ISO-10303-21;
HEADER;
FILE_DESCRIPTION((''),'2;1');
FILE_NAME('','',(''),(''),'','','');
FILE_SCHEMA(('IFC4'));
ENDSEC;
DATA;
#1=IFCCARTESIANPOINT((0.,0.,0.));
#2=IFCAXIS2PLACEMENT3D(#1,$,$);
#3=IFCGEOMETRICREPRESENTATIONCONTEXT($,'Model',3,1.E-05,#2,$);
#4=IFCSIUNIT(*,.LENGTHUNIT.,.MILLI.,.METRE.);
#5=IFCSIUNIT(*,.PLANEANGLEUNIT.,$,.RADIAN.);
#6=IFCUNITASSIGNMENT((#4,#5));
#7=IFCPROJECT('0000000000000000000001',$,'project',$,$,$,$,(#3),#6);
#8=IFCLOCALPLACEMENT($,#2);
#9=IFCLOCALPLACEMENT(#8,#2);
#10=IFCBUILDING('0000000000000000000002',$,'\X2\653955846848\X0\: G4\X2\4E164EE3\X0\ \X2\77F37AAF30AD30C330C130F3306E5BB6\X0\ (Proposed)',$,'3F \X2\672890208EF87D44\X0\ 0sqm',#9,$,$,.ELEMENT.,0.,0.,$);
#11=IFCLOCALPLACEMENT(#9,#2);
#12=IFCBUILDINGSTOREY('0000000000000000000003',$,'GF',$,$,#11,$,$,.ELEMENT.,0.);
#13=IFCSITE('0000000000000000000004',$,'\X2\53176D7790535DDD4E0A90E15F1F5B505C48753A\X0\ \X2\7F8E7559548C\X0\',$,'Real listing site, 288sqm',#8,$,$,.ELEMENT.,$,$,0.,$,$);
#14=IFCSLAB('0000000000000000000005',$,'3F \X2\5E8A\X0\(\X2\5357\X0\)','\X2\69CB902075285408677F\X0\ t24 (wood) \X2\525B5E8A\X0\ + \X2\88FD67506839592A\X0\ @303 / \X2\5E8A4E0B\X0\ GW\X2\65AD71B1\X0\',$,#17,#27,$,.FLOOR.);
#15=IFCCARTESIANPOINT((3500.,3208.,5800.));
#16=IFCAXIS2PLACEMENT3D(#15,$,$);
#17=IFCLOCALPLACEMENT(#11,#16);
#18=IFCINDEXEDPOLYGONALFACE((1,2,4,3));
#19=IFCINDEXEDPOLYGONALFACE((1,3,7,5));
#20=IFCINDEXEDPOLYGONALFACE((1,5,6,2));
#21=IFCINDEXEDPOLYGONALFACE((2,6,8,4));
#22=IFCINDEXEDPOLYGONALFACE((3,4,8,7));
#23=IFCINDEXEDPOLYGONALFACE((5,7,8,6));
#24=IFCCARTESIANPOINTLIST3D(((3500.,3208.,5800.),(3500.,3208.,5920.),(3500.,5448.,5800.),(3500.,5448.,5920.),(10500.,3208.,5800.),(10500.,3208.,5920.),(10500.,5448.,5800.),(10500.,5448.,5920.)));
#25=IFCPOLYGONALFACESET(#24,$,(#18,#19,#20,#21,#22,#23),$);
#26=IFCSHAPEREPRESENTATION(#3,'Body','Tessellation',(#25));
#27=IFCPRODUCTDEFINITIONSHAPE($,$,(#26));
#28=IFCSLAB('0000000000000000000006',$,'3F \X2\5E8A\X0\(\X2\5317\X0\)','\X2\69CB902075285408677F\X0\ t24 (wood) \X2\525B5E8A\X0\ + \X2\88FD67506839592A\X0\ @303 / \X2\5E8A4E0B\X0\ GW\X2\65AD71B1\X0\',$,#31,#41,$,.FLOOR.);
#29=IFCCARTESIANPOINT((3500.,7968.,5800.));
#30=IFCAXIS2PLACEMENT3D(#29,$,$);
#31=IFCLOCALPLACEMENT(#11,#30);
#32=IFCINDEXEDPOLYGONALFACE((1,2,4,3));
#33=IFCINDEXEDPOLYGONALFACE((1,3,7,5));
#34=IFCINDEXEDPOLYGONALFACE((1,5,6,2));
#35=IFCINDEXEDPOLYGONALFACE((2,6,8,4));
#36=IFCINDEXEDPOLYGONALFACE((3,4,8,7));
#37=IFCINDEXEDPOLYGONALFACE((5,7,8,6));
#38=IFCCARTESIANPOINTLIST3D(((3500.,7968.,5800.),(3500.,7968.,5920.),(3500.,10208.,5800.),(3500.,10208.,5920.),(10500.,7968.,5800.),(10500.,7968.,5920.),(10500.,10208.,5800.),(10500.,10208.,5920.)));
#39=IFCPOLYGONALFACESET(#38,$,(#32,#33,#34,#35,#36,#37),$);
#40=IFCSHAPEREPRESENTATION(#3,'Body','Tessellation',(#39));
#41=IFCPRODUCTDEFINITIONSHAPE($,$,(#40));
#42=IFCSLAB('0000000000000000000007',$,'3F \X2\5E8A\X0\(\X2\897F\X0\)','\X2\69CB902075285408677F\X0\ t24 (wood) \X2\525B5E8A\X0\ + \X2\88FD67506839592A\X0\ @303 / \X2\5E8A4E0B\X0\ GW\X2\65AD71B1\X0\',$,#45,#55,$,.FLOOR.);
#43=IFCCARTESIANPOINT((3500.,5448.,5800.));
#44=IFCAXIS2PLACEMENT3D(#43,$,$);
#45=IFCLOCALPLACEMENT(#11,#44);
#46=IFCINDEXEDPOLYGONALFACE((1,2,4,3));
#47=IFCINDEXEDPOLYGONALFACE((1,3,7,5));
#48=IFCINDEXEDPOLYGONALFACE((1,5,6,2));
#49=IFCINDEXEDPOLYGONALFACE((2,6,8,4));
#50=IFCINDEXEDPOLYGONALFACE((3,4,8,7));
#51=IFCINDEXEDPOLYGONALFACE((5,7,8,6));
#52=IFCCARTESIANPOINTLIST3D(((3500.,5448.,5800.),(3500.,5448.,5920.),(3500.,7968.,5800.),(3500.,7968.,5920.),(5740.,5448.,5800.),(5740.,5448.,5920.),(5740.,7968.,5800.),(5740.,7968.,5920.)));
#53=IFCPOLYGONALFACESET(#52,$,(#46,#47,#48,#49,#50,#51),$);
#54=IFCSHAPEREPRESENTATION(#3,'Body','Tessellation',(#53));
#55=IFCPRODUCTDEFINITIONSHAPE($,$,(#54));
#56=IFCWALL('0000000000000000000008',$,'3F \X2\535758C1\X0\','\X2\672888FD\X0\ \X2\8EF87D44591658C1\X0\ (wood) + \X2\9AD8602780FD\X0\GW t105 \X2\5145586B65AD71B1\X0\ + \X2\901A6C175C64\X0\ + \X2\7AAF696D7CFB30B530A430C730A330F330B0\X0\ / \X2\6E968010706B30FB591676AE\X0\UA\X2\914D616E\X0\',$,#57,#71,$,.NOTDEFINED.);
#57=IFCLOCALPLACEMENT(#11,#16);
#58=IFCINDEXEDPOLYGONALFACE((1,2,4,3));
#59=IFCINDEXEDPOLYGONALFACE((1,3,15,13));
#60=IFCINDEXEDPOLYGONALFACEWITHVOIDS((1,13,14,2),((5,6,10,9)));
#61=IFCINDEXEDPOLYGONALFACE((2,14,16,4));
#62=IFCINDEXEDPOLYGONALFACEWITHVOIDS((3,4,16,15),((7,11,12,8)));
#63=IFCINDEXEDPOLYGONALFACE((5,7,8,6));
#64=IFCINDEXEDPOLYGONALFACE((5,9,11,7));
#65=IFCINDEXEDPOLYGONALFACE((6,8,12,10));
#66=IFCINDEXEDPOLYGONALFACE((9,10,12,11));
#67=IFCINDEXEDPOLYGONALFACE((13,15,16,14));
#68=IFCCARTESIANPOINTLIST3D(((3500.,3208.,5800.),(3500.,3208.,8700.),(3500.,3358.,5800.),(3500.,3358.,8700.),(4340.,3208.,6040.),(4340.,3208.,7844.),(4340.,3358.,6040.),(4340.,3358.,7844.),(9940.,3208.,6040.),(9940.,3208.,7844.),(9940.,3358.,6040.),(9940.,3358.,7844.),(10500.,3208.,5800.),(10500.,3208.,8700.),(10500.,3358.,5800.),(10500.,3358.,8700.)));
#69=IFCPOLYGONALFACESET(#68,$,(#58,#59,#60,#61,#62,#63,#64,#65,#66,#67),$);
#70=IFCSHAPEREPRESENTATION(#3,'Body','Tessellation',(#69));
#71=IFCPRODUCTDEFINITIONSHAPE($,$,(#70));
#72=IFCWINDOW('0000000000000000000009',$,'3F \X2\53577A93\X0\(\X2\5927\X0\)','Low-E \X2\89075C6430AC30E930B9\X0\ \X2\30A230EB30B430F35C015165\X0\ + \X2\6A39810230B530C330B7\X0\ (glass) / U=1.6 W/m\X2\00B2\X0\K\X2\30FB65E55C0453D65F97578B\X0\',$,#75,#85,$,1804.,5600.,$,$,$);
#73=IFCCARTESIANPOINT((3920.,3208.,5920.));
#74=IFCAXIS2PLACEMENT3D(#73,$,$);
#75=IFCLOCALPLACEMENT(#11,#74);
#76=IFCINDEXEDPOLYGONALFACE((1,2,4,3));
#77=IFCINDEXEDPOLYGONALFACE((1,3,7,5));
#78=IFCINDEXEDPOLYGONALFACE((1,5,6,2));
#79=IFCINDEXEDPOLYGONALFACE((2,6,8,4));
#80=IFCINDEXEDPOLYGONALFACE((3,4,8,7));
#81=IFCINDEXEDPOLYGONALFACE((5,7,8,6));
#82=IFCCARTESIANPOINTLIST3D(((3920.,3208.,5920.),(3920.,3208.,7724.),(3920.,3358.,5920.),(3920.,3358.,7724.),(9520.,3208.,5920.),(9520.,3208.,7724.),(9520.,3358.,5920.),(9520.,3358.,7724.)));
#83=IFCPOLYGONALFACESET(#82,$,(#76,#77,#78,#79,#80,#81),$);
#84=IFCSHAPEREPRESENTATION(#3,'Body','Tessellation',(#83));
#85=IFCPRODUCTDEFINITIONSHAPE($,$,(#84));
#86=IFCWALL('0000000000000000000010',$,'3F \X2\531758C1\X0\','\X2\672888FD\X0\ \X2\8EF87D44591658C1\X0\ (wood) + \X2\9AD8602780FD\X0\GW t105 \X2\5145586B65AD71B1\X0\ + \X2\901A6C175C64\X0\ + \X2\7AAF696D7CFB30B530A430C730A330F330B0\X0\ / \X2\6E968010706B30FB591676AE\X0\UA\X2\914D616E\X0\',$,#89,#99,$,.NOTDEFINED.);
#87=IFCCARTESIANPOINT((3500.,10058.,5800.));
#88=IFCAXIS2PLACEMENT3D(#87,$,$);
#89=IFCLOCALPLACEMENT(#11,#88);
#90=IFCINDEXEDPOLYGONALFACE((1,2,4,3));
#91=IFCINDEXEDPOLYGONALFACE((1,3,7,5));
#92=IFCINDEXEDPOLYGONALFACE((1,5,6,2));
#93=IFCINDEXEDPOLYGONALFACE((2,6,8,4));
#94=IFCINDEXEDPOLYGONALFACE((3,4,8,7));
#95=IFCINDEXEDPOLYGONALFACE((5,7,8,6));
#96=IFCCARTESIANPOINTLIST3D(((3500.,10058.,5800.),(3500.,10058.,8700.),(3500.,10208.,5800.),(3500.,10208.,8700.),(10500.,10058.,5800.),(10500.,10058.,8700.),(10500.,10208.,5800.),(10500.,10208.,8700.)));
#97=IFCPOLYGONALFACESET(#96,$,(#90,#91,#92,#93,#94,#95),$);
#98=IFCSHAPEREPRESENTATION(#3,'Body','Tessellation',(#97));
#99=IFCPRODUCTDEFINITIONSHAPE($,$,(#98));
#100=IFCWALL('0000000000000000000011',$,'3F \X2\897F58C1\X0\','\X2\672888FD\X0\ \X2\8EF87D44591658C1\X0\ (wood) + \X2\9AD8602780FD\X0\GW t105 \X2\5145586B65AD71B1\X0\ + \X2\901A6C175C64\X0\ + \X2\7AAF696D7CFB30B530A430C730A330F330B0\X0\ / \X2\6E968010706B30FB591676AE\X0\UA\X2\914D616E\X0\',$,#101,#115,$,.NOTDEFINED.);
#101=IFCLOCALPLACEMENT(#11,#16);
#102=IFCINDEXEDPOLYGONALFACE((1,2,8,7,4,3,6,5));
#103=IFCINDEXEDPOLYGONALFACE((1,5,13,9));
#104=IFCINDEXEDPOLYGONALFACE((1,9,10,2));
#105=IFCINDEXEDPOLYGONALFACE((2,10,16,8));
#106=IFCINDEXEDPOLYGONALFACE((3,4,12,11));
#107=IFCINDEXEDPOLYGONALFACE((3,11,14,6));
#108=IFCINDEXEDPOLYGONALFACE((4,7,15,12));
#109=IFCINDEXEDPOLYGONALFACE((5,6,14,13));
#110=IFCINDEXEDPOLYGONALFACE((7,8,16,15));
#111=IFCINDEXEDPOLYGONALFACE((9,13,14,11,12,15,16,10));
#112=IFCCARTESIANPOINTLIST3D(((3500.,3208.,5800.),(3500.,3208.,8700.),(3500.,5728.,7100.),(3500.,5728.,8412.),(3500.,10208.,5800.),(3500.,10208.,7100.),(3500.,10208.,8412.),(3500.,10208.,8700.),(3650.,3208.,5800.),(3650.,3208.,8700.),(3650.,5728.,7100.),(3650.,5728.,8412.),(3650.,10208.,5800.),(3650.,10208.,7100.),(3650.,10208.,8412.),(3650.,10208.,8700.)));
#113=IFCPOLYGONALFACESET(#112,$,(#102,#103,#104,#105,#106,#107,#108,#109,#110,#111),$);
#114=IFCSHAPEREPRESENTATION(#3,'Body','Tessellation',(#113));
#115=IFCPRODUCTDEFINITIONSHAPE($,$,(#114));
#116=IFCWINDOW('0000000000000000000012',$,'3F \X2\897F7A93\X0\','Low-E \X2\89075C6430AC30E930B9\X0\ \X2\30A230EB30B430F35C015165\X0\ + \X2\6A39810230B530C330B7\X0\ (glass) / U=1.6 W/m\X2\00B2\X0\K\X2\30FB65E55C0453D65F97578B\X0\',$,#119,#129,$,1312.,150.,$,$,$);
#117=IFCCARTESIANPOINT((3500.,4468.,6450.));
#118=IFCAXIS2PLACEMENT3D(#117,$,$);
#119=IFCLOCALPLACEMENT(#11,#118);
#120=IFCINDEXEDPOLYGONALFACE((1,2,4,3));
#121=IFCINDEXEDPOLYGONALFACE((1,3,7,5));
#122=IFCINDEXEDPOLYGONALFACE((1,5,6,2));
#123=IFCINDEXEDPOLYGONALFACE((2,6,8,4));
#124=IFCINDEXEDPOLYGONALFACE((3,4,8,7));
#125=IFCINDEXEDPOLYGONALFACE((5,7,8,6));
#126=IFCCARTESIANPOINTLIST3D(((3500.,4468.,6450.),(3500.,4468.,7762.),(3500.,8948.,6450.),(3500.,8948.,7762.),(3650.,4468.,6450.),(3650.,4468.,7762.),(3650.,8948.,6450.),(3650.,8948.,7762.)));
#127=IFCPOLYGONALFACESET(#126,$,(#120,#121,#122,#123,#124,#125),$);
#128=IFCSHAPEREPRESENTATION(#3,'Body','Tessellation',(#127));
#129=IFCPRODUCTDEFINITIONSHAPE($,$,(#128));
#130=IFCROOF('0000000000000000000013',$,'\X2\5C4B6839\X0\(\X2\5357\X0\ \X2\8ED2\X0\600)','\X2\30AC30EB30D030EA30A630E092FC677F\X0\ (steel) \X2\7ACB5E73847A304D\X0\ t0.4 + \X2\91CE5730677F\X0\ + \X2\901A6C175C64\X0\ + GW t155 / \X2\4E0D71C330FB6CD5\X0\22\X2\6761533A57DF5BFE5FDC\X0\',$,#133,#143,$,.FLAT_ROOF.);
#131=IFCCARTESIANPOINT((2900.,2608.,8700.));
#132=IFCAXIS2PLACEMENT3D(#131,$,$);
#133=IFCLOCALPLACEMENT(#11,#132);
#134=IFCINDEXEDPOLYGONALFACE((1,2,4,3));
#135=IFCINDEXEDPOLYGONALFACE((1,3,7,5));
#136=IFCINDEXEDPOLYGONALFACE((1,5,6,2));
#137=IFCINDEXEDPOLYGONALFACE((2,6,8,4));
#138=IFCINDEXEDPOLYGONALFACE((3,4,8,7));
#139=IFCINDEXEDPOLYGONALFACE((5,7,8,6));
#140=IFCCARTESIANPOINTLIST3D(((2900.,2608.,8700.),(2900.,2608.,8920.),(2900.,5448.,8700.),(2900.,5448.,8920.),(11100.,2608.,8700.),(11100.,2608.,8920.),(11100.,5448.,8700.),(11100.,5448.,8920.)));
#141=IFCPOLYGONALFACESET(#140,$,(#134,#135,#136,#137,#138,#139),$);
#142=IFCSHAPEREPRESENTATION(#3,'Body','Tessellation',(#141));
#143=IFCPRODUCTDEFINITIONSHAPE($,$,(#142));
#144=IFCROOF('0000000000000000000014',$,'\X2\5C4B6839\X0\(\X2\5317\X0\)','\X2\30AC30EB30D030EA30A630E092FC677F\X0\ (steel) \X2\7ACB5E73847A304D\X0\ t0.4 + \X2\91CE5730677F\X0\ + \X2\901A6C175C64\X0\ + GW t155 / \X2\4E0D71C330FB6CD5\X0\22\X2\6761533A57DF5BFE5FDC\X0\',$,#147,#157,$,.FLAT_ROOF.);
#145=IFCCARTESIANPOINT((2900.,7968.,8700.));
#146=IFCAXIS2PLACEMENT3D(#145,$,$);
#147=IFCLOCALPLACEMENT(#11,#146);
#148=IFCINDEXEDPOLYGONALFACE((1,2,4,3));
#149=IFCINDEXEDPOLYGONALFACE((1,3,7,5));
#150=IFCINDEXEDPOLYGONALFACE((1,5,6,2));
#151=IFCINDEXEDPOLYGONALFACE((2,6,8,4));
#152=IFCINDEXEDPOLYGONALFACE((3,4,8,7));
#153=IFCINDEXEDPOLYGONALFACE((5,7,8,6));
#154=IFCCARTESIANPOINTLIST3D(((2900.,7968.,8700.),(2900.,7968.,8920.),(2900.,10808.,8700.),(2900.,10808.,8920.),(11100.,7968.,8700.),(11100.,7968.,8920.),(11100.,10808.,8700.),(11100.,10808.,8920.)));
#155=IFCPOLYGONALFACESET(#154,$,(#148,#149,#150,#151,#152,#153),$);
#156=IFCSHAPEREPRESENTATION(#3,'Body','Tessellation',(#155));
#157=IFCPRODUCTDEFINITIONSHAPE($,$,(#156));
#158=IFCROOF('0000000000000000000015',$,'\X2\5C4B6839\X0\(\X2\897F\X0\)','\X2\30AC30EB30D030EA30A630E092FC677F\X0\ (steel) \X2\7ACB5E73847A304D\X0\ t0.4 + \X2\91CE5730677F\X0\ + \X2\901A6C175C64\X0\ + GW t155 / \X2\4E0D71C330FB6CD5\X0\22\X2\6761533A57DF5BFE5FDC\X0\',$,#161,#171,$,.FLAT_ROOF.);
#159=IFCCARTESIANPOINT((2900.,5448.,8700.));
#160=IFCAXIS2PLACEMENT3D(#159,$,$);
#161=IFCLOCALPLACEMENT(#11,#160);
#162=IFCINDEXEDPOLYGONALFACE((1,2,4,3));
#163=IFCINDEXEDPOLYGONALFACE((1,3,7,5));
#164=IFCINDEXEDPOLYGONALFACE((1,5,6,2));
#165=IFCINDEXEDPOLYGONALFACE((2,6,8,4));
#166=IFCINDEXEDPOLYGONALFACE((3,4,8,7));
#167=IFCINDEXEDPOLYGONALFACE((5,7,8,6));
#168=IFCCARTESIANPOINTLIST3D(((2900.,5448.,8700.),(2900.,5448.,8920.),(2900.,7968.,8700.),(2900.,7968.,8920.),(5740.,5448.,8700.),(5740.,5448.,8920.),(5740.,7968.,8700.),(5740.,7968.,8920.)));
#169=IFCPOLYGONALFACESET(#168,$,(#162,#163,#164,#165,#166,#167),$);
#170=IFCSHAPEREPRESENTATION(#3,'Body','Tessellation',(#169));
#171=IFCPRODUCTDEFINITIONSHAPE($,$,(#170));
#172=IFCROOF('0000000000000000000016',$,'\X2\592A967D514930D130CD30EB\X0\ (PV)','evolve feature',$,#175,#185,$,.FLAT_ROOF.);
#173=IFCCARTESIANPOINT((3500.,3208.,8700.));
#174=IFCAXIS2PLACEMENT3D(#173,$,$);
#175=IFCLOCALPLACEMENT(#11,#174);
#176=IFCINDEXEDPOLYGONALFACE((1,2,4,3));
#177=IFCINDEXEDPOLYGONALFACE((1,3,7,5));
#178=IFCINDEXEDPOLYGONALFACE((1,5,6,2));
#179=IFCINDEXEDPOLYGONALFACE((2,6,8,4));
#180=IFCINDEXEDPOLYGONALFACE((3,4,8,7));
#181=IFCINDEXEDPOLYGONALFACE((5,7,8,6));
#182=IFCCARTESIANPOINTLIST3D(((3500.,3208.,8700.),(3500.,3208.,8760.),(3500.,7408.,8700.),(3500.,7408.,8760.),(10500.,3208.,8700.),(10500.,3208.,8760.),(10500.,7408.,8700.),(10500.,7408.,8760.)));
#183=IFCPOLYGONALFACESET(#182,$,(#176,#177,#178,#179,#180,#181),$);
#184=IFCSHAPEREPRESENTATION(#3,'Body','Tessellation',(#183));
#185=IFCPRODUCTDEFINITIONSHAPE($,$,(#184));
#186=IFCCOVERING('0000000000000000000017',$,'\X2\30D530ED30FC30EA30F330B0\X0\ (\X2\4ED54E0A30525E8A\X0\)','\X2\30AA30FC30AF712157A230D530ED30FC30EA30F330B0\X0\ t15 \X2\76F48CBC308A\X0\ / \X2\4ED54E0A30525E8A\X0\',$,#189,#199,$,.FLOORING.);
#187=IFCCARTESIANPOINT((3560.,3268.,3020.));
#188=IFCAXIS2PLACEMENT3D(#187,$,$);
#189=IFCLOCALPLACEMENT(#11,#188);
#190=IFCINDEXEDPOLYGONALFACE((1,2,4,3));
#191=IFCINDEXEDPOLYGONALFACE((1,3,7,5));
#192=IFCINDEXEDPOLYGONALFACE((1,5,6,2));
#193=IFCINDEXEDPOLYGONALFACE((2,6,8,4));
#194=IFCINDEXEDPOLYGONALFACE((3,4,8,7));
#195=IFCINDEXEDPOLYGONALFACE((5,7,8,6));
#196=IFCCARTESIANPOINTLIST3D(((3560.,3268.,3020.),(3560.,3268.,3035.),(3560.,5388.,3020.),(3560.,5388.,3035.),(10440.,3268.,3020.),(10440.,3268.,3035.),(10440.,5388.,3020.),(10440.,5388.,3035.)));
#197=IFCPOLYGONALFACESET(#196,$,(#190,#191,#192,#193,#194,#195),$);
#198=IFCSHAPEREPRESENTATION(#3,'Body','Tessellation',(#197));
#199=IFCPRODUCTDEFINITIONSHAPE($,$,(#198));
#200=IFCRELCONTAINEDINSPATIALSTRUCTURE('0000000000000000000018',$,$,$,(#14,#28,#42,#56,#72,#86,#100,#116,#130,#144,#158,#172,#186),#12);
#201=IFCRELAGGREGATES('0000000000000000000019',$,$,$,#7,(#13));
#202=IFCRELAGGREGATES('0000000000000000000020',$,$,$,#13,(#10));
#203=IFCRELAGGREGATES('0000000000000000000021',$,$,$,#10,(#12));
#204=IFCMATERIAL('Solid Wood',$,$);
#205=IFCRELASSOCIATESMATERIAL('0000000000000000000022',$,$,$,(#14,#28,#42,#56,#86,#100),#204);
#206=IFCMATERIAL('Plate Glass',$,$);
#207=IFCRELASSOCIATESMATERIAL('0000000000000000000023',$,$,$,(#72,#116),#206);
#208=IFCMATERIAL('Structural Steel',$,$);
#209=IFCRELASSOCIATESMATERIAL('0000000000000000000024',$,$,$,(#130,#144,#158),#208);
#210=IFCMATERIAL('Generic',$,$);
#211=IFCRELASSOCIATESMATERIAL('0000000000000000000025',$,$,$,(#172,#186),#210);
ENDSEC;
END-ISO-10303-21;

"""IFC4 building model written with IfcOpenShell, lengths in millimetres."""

from ifc_helpers import new_model, si_unit, frame, frame_2d, origin, place, context, project, spatial, rectangle, extrude, material, element, fill, save


model = new_model("IFC4")

# Units and contexts
model_context = context("Model", 3, precision=1e-05, world=origin())
ifc_project = project(units=[si_unit("LENGTHUNIT", "METRE", prefix="MILLI"), si_unit("PLANEANGLEUNIT", "RADIAN")], contexts=[model_context])

# Site, building, storey
site_placement = place(None, origin())
site = spatial("IfcSite", under=ifc_project, at=site_placement, Name="北海道川上郡弟子屈町 美留和", ObjectType="Real listing site, 288sqm", CompositionType="ELEMENT", RefElevation=0.0)
building_placement = place(site_placement, origin())
building = spatial("IfcBuilding", under=site, at=building_placement, Name="改善案: G4世代 石窯キッチンの家 (Proposed)", ObjectType="3F 木造軸組 0sqm", CompositionType="ELEMENT", ElevationOfRefHeight=0.0, ElevationOfTerrain=0.0)
storey_placement = place(building_placement, origin())
storey = spatial("IfcBuildingStorey", under=building, at=storey_placement, Name="GF", CompositionType="ELEMENT", Elevation=0.0)

# Slabs
ifc_material_1 = material(Name="Solid Wood")
slab_1_placement = place(storey_placement, frame((3500.0, 3208.0, 5800.0)))
element("IfcSlab", 1, at=slab_1_placement, inside=storey, material=ifc_material_1, Name="3F 床(南)", Description="構造用合板 t24 (wood) 剛床 + 製材根太 @303 / 床下 GW断熱", PredefinedType="FLOOR", context=model_context, shape_type="SweptSolid", body=[
    extrude(rectangle(XDim=7000.0, YDim=2240.0, at=frame_2d((3500.0, 1120.0))), frame((3500.0, 3208.0, 5800.0)), (0.0, 0.0, 1.0), 120.0),
])
slab_2_placement = place(storey_placement, frame((3500.0, 7968.0, 5800.0)))
element("IfcSlab", 2, at=slab_2_placement, inside=storey, material=ifc_material_1, Name="3F 床(北)", Description="構造用合板 t24 (wood) 剛床 + 製材根太 @303 / 床下 GW断熱", PredefinedType="FLOOR", context=model_context, shape_type="SweptSolid", body=[
    extrude(rectangle(XDim=7000.0, YDim=2240.0, at=frame_2d((3500.0, 1120.0))), frame((3500.0, 7968.0, 5800.0)), (0.0, 0.0, 1.0), 120.0),
])
slab_3_placement = place(storey_placement, frame((3500.0, 5448.0, 5800.0)))
element("IfcSlab", 3, at=slab_3_placement, inside=storey, material=ifc_material_1, Name="3F 床(西)", Description="構造用合板 t24 (wood) 剛床 + 製材根太 @303 / 床下 GW断熱", PredefinedType="FLOOR", context=model_context, shape_type="SweptSolid", body=[
    extrude(rectangle(XDim=2240.0, YDim=2520.0, at=frame_2d((1120.0, 1260.0))), frame((3500.0, 5448.0, 5800.0)), (0.0, 0.0, 1.0), 120.0),
])

# Wall, opening, window
wall_1_placement = place(storey_placement, frame((3500.0, 3208.0, 5800.0)))
wall_1 = element("IfcWall", 4, at=wall_1_placement, inside=storey, material=ifc_material_1, Name="3F 南壁", Description="木製 軸組外壁 (wood) + 高性能GW t105 充填断熱 + 通気層 + 窯業系サイディング / 準耐火・外皮UA配慮", PredefinedType="NOTDEFINED", context=model_context, shape_type="SweptSolid", body=[
    extrude(rectangle(XDim=7000.0, YDim=150.0, at=frame_2d((3500.0, 75.0))), frame((3500.0, 3208.0, 5800.0)), (0.0, 0.0, 1.0), 2900.0),
])
opening_1_placement = place(storey_placement, frame((3920.0, 3208.0, 5920.0)))
opening_1 = element("IfcOpeningElement", 5, at=opening_1_placement, cuts=wall_1, PredefinedType="NOTDEFINED", context=model_context, shape_type="SweptSolid", body=[
    extrude(rectangle(XDim=5600.0, YDim=150.0, at=frame_2d((2800.0, 75.0))), frame((3920.0, 3208.0, 5920.0)), (0.0, 0.0, 1.0), 1804.0),
])
ifc_material_2 = material(Name="Plate Glass")
window_1_placement = place(storey_placement, frame((3920.0, 3208.0, 5920.0)))
window_1 = element("IfcWindow", 6, at=window_1_placement, inside=storey, material=ifc_material_2, Name="3F 南窓(大)", Description="Low-E 複層ガラス アルゴン封入 + 樹脂サッシ (glass) / U=1.6 W/m²K・日射取得型", OverallHeight=1804.0, OverallWidth=5600.0, context=model_context, shape_type="SweptSolid", body=[
    extrude(rectangle(XDim=5600.0, YDim=150.0, at=frame_2d((2800.0, 75.0))), frame((3920.0, 3208.0, 5920.0)), (0.0, 0.0, 1.0), 1804.0),
])
fill(opening_1, window_1)

# Wall
wall_2_placement = place(storey_placement, frame((3500.0, 10058.0, 5800.0)))
element("IfcWall", 7, at=wall_2_placement, inside=storey, material=ifc_material_1, Name="3F 北壁", Description="木製 軸組外壁 (wood) + 高性能GW t105 充填断熱 + 通気層 + 窯業系サイディング / 準耐火・外皮UA配慮", PredefinedType="NOTDEFINED", context=model_context, shape_type="SweptSolid", body=[
    extrude(rectangle(XDim=7000.0, YDim=150.0, at=frame_2d((3500.0, 75.0))), frame((3500.0, 10058.0, 5800.0)), (0.0, 0.0, 1.0), 2900.0),
])

# Wall, opening, window
wall_3_placement = place(storey_placement, frame((3500.0, 3208.0, 5800.0)))
wall_3 = element("IfcWall", 8, at=wall_3_placement, inside=storey, material=ifc_material_1, Name="3F 西壁", Description="木製 軸組外壁 (wood) + 高性能GW t105 充填断熱 + 通気層 + 窯業系サイディング / 準耐火・外皮UA配慮", PredefinedType="NOTDEFINED", context=model_context, shape_type="SweptSolid", body=[
    extrude(rectangle(XDim=150.0, YDim=7000.0, at=frame_2d((75.0, 3500.0))), frame((3500.0, 3208.0, 5800.0)), (0.0, 0.0, 1.0), 2900.0),
])
opening_2_placement = place(storey_placement, frame((3500.0, 4468.0, 6450.0)))
opening_2 = element("IfcOpeningElement", 9, at=opening_2_placement, cuts=wall_3, PredefinedType="NOTDEFINED", context=model_context, shape_type="SweptSolid", body=[
    extrude(rectangle(XDim=150.0, YDim=4480.0, at=frame_2d((75.0, 2240.0))), frame((3500.0, 4468.0, 6450.0)), (0.0, 0.0, 1.0), 1312.0),
])
window_2_placement = place(storey_placement, frame((3500.0, 4468.0, 6450.0)))
window_2 = element("IfcWindow", 10, at=window_2_placement, inside=storey, material=ifc_material_2, Name="3F 西窓", Description="Low-E 複層ガラス アルゴン封入 + 樹脂サッシ (glass) / U=1.6 W/m²K・日射取得型", OverallHeight=1312.0, OverallWidth=150.0, context=model_context, shape_type="SweptSolid", body=[
    extrude(rectangle(XDim=150.0, YDim=4480.0, at=frame_2d((75.0, 2240.0))), frame((3500.0, 4468.0, 6450.0)), (0.0, 0.0, 1.0), 1312.0),
])
fill(opening_2, window_2)

# Roofs
ifc_material_3 = material(Name="Structural Steel")
roof_1_placement = place(storey_placement, frame((2900.0, 2608.0, 8700.0)))
element("IfcRoof", 11, at=roof_1_placement, inside=storey, material=ifc_material_3, Name="屋根(南 軒600)", Description="ガルバリウム鋼板 (steel) 立平葺き t0.4 + 野地板 + 通気層 + GW t155 / 不燃・法22条区域対応", PredefinedType="FLAT_ROOF", context=model_context, shape_type="SweptSolid", body=[
    extrude(rectangle(XDim=8200.0, YDim=2840.0, at=frame_2d((4100.0, 1420.0))), frame((2900.0, 2608.0, 8700.0)), (0.0, 0.0, 1.0), 220.0),
])
roof_2_placement = place(storey_placement, frame((2900.0, 7968.0, 8700.0)))
element("IfcRoof", 12, at=roof_2_placement, inside=storey, material=ifc_material_3, Name="屋根(北)", Description="ガルバリウム鋼板 (steel) 立平葺き t0.4 + 野地板 + 通気層 + GW t155 / 不燃・法22条区域対応", PredefinedType="FLAT_ROOF", context=model_context, shape_type="SweptSolid", body=[
    extrude(rectangle(XDim=8200.0, YDim=2840.0, at=frame_2d((4100.0, 1420.0))), frame((2900.0, 7968.0, 8700.0)), (0.0, 0.0, 1.0), 220.0),
])
roof_3_placement = place(storey_placement, frame((2900.0, 5448.0, 8700.0)))
element("IfcRoof", 13, at=roof_3_placement, inside=storey, material=ifc_material_3, Name="屋根(西)", Description="ガルバリウム鋼板 (steel) 立平葺き t0.4 + 野地板 + 通気層 + GW t155 / 不燃・法22条区域対応", PredefinedType="FLAT_ROOF", context=model_context, shape_type="SweptSolid", body=[
    extrude(rectangle(XDim=2840.0, YDim=2520.0, at=frame_2d((1420.0, 1260.0))), frame((2900.0, 5448.0, 8700.0)), (0.0, 0.0, 1.0), 220.0),
])
ifc_material_4 = material(Name="Generic")
roof_4_placement = place(storey_placement, frame((3500.0, 3208.0, 8700.0)))
element("IfcRoof", 14, at=roof_4_placement, inside=storey, material=ifc_material_4, Name="太陽光パネル (PV)", Description="evolve feature", PredefinedType="FLAT_ROOF", context=model_context, shape_type="SweptSolid", body=[
    extrude(rectangle(XDim=7000.0, YDim=4200.0, at=frame_2d((3500.0, 2100.0))), frame((3500.0, 3208.0, 8700.0)), (0.0, 0.0, 1.0), 60.0),
])

# Covering
covering_1_placement = place(storey_placement, frame((3560.0, 3268.0, 3020.0)))
element("IfcCovering", 15, at=covering_1_placement, inside=storey, material=ifc_material_4, Name="フローリング (仕上げ床)", Description="オーク無垢フローリング t15 直貼り / 仕上げ床", PredefinedType="FLOORING", context=model_context, shape_type="SweptSolid", body=[
    extrude(rectangle(XDim=6880.0, YDim=2120.0, at=frame_2d((3440.0, 1060.0))), frame((3560.0, 3268.0, 3020.0)), (0.0, 0.0, 1.0), 15.0),
])

save(model, "model.ifc")
